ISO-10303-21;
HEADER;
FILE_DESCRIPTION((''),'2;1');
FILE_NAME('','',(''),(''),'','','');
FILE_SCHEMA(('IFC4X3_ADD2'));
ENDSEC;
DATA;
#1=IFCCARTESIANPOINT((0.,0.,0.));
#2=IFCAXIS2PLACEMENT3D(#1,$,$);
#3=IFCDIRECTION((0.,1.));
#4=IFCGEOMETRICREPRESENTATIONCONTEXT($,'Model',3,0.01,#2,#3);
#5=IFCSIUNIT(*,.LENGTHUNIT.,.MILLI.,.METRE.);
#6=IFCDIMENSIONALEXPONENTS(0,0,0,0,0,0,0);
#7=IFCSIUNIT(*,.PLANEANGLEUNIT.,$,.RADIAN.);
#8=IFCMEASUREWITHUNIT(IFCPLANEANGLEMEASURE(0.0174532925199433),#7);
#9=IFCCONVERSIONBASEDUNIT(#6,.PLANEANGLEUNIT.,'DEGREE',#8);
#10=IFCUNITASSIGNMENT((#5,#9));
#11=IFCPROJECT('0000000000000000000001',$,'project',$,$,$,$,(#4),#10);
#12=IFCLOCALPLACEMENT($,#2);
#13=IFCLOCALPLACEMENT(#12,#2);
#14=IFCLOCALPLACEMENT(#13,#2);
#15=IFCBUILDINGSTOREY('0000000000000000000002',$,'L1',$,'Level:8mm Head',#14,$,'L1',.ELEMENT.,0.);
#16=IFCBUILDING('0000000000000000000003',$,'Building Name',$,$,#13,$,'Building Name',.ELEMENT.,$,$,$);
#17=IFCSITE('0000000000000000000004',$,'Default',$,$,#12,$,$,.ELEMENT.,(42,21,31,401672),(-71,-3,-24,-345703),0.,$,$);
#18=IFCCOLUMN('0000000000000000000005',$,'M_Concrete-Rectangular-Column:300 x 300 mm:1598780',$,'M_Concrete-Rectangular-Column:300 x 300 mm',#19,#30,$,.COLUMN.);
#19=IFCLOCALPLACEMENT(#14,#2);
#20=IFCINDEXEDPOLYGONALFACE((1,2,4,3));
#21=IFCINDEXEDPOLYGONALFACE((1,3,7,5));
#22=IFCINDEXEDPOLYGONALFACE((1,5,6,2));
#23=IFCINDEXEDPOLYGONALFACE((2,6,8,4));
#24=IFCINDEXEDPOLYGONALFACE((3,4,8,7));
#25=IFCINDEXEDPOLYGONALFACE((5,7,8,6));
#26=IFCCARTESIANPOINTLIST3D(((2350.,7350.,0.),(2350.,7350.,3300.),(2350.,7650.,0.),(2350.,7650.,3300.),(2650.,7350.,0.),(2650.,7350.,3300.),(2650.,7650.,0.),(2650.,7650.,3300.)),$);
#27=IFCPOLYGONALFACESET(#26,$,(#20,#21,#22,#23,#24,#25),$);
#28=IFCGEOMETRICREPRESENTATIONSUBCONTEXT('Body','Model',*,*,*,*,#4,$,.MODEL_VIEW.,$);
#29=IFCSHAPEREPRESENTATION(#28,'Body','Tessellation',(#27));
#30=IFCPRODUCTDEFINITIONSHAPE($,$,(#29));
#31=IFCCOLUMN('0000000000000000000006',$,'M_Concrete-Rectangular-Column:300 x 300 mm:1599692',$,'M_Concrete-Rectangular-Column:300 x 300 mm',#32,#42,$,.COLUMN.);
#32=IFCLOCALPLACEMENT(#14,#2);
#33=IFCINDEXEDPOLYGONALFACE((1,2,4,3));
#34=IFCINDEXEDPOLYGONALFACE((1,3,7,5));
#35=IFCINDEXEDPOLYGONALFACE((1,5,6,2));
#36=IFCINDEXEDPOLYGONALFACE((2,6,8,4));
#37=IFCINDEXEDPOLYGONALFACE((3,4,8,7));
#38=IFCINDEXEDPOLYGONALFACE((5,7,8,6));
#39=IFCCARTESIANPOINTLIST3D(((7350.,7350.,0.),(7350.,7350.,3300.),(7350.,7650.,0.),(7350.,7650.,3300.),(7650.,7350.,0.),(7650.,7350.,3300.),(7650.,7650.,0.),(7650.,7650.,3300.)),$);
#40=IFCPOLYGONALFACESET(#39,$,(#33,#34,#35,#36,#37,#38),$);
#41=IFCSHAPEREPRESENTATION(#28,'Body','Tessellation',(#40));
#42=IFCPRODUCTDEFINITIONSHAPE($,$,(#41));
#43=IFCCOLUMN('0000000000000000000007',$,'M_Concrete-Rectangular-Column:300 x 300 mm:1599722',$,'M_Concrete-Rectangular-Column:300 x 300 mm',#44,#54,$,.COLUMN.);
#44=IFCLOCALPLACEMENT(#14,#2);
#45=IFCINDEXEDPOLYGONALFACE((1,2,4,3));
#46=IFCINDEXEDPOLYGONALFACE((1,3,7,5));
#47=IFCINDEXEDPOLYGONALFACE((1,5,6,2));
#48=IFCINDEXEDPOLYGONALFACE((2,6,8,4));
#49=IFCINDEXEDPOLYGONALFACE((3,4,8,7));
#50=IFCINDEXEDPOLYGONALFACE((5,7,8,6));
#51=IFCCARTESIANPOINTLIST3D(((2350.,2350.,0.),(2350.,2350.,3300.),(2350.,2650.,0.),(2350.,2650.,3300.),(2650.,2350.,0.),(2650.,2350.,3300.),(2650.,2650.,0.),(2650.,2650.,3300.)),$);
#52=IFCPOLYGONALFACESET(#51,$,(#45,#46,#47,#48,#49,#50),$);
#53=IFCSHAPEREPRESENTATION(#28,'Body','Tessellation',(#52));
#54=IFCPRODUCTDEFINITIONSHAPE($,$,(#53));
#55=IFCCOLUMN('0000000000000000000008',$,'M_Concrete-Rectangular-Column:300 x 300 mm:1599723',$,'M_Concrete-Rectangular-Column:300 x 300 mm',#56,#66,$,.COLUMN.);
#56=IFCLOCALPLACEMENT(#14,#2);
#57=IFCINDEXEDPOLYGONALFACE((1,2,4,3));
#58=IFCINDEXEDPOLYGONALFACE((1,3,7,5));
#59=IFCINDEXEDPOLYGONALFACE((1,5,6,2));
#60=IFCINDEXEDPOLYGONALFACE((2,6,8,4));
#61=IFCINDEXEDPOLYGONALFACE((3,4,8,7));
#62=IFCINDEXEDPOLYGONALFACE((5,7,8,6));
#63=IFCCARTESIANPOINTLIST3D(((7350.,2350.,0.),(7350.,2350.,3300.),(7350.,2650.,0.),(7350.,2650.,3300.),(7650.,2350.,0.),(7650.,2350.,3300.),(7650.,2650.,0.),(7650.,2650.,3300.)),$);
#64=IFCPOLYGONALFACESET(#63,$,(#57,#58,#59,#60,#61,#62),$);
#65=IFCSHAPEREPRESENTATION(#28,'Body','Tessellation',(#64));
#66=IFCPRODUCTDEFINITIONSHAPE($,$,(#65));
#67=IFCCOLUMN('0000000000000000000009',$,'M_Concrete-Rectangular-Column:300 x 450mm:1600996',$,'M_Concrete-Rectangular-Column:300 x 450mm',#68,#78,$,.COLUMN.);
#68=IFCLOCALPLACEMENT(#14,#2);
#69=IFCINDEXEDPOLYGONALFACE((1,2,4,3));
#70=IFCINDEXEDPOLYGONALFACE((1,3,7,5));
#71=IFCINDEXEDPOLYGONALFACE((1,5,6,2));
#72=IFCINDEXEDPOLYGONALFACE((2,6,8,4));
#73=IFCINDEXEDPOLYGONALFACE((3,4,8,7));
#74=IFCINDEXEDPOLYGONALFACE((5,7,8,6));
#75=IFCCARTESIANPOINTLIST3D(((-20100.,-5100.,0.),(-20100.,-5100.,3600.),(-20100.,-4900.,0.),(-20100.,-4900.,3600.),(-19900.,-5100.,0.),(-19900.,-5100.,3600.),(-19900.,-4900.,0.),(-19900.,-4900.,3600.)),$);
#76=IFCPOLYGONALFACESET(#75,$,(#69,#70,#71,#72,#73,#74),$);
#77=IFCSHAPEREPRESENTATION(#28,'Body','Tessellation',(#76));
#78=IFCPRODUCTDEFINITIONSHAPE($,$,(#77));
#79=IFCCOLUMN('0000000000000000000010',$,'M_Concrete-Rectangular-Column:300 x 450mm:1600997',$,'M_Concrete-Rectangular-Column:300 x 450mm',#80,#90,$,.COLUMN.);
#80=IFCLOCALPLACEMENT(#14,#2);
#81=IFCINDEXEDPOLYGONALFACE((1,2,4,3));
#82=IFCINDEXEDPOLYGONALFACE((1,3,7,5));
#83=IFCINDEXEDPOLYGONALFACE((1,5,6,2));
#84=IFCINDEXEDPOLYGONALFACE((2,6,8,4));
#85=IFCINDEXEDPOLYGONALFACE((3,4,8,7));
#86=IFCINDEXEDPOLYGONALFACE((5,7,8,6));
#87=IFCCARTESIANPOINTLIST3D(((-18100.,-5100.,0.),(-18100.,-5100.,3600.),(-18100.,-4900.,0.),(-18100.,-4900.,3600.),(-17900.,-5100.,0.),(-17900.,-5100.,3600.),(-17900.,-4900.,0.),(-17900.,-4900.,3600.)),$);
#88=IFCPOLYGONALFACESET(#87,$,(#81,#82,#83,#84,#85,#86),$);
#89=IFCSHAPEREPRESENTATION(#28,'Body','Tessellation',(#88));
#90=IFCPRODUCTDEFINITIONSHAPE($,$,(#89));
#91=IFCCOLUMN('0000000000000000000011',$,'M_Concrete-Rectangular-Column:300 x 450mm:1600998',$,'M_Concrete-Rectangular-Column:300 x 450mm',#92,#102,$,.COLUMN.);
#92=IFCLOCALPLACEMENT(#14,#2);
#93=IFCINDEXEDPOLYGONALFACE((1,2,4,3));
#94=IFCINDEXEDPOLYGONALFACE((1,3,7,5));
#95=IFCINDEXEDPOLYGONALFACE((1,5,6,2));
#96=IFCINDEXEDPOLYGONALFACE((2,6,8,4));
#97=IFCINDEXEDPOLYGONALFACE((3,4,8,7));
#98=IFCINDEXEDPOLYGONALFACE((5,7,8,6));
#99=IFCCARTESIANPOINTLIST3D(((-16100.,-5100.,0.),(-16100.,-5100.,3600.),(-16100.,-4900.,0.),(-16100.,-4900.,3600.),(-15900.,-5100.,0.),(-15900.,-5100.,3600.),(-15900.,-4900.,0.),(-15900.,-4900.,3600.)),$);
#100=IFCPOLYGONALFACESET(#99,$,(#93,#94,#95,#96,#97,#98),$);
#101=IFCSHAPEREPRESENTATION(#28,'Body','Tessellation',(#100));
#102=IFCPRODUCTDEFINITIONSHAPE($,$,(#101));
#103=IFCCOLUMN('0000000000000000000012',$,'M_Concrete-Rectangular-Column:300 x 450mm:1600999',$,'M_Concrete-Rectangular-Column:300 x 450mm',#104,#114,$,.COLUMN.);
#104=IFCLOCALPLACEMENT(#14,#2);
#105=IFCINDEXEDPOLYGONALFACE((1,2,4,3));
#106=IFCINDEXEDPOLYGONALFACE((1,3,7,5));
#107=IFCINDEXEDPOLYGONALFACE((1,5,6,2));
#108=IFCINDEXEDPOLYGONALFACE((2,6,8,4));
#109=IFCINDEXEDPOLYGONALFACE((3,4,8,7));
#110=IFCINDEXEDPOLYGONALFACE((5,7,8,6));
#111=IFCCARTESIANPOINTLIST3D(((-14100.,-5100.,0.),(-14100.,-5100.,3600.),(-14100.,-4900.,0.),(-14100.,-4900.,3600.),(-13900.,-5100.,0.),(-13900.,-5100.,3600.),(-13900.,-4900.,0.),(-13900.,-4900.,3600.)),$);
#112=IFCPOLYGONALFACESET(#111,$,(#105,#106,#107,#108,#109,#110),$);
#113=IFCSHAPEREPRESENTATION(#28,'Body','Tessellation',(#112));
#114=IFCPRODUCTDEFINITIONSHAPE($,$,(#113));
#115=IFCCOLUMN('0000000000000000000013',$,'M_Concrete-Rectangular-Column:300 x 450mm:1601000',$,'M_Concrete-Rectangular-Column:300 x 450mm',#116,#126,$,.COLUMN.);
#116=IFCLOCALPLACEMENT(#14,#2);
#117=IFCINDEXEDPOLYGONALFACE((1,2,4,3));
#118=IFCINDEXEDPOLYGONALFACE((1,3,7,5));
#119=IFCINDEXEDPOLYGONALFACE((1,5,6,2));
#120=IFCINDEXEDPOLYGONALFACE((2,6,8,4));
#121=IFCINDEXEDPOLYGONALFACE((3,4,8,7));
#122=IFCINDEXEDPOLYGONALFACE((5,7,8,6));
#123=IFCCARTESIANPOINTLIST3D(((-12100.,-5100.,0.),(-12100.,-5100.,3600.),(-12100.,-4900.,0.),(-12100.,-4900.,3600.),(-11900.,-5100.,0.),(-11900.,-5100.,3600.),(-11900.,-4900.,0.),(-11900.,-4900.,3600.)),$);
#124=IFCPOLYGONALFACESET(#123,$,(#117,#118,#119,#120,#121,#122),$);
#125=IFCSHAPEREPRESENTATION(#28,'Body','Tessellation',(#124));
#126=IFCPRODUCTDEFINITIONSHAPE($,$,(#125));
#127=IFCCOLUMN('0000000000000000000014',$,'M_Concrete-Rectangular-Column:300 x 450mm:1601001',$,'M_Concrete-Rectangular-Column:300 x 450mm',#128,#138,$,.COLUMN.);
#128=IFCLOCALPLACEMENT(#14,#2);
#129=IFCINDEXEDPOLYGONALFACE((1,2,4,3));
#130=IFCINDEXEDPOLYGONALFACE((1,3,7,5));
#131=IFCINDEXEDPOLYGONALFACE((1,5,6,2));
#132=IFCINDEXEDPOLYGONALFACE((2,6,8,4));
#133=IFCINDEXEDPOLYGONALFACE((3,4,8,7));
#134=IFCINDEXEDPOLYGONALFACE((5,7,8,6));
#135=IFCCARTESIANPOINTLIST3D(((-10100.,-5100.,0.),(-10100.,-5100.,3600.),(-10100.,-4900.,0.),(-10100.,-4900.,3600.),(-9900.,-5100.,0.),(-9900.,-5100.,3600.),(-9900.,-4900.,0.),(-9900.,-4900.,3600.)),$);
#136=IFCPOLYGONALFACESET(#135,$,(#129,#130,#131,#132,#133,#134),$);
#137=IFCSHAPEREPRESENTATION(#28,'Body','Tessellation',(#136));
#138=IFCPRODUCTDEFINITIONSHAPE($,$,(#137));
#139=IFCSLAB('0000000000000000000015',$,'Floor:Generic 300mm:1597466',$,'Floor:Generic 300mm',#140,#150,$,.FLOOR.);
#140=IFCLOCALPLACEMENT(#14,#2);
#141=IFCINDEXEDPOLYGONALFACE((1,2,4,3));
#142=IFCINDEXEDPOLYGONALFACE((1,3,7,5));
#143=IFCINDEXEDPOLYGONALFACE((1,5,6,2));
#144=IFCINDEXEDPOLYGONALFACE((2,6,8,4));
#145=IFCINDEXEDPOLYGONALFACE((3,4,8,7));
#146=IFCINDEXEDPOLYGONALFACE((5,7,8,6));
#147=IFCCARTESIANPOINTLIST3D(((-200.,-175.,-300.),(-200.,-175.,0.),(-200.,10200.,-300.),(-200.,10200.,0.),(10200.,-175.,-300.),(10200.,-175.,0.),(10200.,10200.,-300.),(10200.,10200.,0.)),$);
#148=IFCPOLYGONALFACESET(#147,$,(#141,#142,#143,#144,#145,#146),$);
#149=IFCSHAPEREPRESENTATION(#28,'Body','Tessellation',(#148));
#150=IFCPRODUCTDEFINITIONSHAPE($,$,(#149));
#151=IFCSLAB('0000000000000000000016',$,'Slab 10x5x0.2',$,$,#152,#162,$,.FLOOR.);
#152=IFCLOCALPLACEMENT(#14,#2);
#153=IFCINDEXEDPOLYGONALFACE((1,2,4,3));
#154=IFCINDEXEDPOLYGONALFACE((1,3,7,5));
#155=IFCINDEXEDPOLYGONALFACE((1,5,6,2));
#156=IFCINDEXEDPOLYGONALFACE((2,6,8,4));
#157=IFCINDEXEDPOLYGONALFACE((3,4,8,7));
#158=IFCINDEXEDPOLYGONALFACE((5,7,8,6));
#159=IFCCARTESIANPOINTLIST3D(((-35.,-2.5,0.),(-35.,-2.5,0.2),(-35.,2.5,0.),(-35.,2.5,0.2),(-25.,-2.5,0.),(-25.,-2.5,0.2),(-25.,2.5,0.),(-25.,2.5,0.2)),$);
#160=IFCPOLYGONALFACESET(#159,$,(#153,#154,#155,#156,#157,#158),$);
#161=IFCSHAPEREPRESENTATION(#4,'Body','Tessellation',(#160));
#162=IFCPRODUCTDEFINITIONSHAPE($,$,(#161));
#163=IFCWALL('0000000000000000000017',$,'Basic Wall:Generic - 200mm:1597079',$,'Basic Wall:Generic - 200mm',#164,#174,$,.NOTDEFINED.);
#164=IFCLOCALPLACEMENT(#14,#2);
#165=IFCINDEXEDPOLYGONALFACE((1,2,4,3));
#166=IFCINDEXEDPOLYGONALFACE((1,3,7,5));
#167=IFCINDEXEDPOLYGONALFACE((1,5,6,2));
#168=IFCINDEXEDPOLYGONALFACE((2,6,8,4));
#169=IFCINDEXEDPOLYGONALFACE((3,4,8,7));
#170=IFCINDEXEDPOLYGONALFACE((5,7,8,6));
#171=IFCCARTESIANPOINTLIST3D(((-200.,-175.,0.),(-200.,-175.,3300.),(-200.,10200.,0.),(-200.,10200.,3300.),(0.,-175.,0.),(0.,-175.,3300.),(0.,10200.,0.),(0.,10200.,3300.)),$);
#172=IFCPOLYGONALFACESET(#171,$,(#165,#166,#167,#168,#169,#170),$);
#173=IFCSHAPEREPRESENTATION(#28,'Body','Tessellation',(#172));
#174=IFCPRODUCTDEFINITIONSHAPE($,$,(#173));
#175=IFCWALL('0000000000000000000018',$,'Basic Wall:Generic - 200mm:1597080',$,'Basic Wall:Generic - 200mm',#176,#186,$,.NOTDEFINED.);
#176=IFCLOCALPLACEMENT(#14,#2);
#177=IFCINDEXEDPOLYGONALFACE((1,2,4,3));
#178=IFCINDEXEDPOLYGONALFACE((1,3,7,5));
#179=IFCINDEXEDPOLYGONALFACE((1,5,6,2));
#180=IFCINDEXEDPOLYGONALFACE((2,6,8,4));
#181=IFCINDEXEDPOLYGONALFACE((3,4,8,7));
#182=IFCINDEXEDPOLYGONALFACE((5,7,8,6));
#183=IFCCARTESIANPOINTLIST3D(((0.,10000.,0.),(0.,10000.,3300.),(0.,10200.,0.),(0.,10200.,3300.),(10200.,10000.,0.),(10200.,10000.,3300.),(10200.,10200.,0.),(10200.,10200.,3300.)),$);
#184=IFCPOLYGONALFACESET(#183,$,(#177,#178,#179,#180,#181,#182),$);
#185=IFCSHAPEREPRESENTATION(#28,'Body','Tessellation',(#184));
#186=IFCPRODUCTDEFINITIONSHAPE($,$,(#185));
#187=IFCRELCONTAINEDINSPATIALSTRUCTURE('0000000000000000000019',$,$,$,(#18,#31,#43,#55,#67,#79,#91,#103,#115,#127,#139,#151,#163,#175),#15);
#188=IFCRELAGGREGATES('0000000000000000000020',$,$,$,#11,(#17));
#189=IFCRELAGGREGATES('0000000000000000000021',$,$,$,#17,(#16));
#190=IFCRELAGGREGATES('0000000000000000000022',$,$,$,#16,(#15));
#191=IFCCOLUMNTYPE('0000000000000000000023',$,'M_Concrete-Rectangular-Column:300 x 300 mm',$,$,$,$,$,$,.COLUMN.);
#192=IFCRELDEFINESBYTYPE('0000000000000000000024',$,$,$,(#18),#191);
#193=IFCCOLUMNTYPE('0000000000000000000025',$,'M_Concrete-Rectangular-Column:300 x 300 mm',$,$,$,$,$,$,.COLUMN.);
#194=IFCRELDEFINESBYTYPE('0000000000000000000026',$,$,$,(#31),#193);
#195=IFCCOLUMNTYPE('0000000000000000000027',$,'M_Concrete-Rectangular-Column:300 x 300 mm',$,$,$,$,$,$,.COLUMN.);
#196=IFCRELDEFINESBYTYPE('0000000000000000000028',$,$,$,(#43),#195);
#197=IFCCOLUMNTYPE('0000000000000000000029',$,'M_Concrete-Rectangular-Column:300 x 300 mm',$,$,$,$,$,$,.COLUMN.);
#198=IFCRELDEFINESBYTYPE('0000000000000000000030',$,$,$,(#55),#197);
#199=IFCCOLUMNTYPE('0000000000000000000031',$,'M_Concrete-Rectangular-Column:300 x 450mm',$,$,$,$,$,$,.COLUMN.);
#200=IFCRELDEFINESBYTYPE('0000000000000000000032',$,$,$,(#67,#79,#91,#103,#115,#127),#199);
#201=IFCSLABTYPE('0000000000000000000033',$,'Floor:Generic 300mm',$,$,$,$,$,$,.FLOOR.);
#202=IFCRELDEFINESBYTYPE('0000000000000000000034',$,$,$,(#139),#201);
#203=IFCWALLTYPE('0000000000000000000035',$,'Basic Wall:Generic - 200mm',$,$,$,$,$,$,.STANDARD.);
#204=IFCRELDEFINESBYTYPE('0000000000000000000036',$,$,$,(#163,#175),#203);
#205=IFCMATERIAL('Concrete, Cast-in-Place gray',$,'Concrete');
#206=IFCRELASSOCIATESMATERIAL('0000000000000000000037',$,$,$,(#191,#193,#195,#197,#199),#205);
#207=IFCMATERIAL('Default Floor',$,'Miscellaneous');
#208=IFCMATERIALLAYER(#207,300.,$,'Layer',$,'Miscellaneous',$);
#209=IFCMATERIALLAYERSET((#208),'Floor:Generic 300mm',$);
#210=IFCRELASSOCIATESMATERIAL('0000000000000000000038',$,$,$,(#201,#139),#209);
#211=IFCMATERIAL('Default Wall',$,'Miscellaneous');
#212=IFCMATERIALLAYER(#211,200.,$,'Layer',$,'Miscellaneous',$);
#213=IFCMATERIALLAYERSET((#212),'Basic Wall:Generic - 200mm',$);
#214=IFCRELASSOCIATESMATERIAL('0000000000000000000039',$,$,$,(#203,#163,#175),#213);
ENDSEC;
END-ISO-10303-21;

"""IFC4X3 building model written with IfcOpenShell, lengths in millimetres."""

from ifc_helpers import new_model, entity, si_unit, converted_unit, direction, frame, frame_2d, origin, origin_with_axes, origin_2d, origin_2d_with_axis, place, context, subcontext, project, spatial, rectangle, extrude, source, transform, mapped, material, layer, layer_set, layer_usage, material_profile, profile_set, type_object, type_shapes, element, save


model = new_model("IFC4X3")

# Units and contexts
model_context = context("Model", 3, precision=0.01, world=origin(), true_north=direction((0.0, 1.0)))
body_context = subcontext(model_context, "Body", "Model", "MODEL_VIEW")
ifc_project = project(units=[si_unit("LENGTHUNIT", "METRE", prefix="MILLI"), converted_unit("PLANEANGLEUNIT", "DEGREE", entity("IfcPlaneAngleMeasure", 0.0174532925199433), si_unit("PLANEANGLEUNIT", "RADIAN"), dimensions=[0, 0, 0, 0, 0, 0, 0])], contexts=[model_context])

# Site, building, storey
site_placement = place(None, origin())
site = spatial("IfcSite", under=ifc_project, at=site_placement, Name="Default", CompositionType="ELEMENT", RefLatitude=(42, 21, 31, 401672), RefLongitude=(-71, -3, -24, -345703), RefElevation=0.0)
building_placement = place(site_placement, origin())
building = spatial("IfcBuilding", under=site, at=building_placement, Name="Building Name", LongName="Building Name", CompositionType="ELEMENT")
storey_placement = place(building_placement, origin())
storey = spatial("IfcBuildingStorey", under=building, at=storey_placement, Name="L1", ObjectType="Level:8mm Head", LongName="L1", CompositionType="ELEMENT", Elevation=0.0)

# Columns
ifc_material_1 = material(Name="Concrete, Cast-in-Place gray", Category="Concrete")
ifc_material_profile_1 = material_profile(ifc_material_1, rectangle(XDim=300.0, YDim=300.0, at=origin_2d_with_axis()), Name="300 x 300 mm")
ifc_profile_set_1 = profile_set([ifc_material_profile_1], Name="300 x 300 mm")
column_type_1 = type_object("IfcColumnType", Name="M_Concrete-Rectangular-Column:300 x 300 mm", PredefinedType="COLUMN", material=ifc_profile_set_1)
shared_shape_1 = source(origin(), body_context, "Body", "SweptSolid", [
    extrude(rectangle(XDim=300.0, YDim=300.0, at=origin_2d_with_axis()), frame((2500.0, 7500.0, 0.0)), (0.0, 0.0, 1.0), 3300.0),
])
type_shapes(column_type_1, [shared_shape_1])
column_1_placement = place(storey_placement, origin())
element("IfcColumn", 1, at=column_1_placement, inside=storey, type_object=column_type_1, Name="M_Concrete-Rectangular-Column:300 x 300 mm:1598780", ObjectType="M_Concrete-Rectangular-Column:300 x 300 mm", PredefinedType="COLUMN", context=body_context, shape_type="MappedRepresentation", body=[
    mapped(shared_shape_1, transform((0.0, 0.0, 0.0), scale=1.0)),
])
column_type_2 = type_object("IfcColumnType", Name="M_Concrete-Rectangular-Column:300 x 300 mm", PredefinedType="COLUMN", material=ifc_profile_set_1)
shared_shape_2 = source(origin(), body_context, "Body", "SweptSolid", [
    extrude(rectangle(XDim=300.0, YDim=300.0, at=origin_2d_with_axis()), frame((7500.0, 7500.0, 0.0)), (0.0, 0.0, 1.0), 3300.0),
])
type_shapes(column_type_2, [shared_shape_2])
column_2_placement = place(storey_placement, origin())
element("IfcColumn", 2, at=column_2_placement, inside=storey, type_object=column_type_2, Name="M_Concrete-Rectangular-Column:300 x 300 mm:1599692", ObjectType="M_Concrete-Rectangular-Column:300 x 300 mm", PredefinedType="COLUMN", context=body_context, shape_type="MappedRepresentation", body=[
    mapped(shared_shape_2, transform((0.0, 0.0, 0.0), scale=1.0)),
])
column_type_3 = type_object("IfcColumnType", Name="M_Concrete-Rectangular-Column:300 x 300 mm", PredefinedType="COLUMN", material=ifc_profile_set_1)
shared_shape_3 = source(origin(), body_context, "Body", "SweptSolid", [
    extrude(rectangle(XDim=300.0, YDim=300.0, at=origin_2d_with_axis()), frame((2500.0, 2500.0, 0.0)), (0.0, 0.0, 1.0), 3300.0),
])
type_shapes(column_type_3, [shared_shape_3])
column_3_placement = place(storey_placement, origin())
element("IfcColumn", 3, at=column_3_placement, inside=storey, type_object=column_type_3, Name="M_Concrete-Rectangular-Column:300 x 300 mm:1599722", ObjectType="M_Concrete-Rectangular-Column:300 x 300 mm", PredefinedType="COLUMN", context=body_context, shape_type="MappedRepresentation", body=[
    mapped(shared_shape_3, transform((0.0, 0.0, 0.0), scale=1.0)),
])
column_type_4 = type_object("IfcColumnType", Name="M_Concrete-Rectangular-Column:300 x 300 mm", PredefinedType="COLUMN", material=ifc_profile_set_1)
shared_shape_4 = source(origin(), body_context, "Body", "SweptSolid", [
    extrude(rectangle(XDim=300.0, YDim=300.0, at=origin_2d_with_axis()), frame((7500.0, 2500.0, 0.0)), (0.0, 0.0, 1.0), 3300.0),
])
type_shapes(column_type_4, [shared_shape_4])
column_4_placement = place(storey_placement, origin())
element("IfcColumn", 4, at=column_4_placement, inside=storey, type_object=column_type_4, Name="M_Concrete-Rectangular-Column:300 x 300 mm:1599723", ObjectType="M_Concrete-Rectangular-Column:300 x 300 mm", PredefinedType="COLUMN", context=body_context, shape_type="MappedRepresentation", body=[
    mapped(shared_shape_4, transform((0.0, 0.0, 0.0), scale=1.0)),
])
ifc_material_profile_2 = material_profile(ifc_material_1, rectangle(XDim=200.0, YDim=200.0, at=origin_2d_with_axis()), Name="300 x 450mm")
ifc_profile_set_2 = profile_set([ifc_material_profile_2], Name="300 x 450mm")
column_type_5 = type_object("IfcColumnType", Name="M_Concrete-Rectangular-Column:300 x 450mm", PredefinedType="COLUMN", material=ifc_profile_set_2)
shared_shape_5 = source(origin(), body_context, "Body", "SweptSolid", [
    extrude(rectangle(XDim=200.0, YDim=200.0, at=origin_2d_with_axis()), frame((0.0, 0.0, 0.0), z_axis=(0.0, 0.0, 1.0), x_axis=(-1.0, 0.0, 0.0)), (0.0, 0.0, 1.0), 3600.0),
])
type_shapes(column_type_5, [shared_shape_5])
for number, where, z_axis, x_axis, name in (
    (5, (-20000.0, -5000.0, 0.0), (0.0, 0.0, 1.0), (0.0, -1.0, 0.0), "M_Concrete-Rectangular-Column:300 x 450mm:1600996"),
    (6, (-18000.0, -5000.0, 0.0), (0.0, 0.0, 1.0), (0.0, -1.0, 0.0), "M_Concrete-Rectangular-Column:300 x 450mm:1600997"),
    (7, (-16000.0, -5000.0, 0.0), (0.0, 0.0, 1.0), (0.0, -1.0, 0.0), "M_Concrete-Rectangular-Column:300 x 450mm:1600998"),
    (8, (-14000.0, -5000.0, 0.0), (0.0, 0.0, 1.0), (0.0, -1.0, 0.0), "M_Concrete-Rectangular-Column:300 x 450mm:1600999"),
    (9, (-12000.0, -5000.0, 0.0), (0.0, 0.0, 1.0), (0.0, -1.0, 0.0), "M_Concrete-Rectangular-Column:300 x 450mm:1601000"),
    (10, (-10000.0, -5000.0, 0.0), (0.0, 0.0, 1.0), (0.0, -1.0, 0.0), "M_Concrete-Rectangular-Column:300 x 450mm:1601001"),
):
    element("IfcColumn", number, at=place(storey_placement, frame(where, z_axis=z_axis, x_axis=x_axis)), inside=storey, type_object=column_type_5, Name=name, ObjectType="M_Concrete-Rectangular-Column:300 x 450mm", PredefinedType="COLUMN", context=body_context, shape_type="MappedRepresentation", body=[
        mapped(shared_shape_5, transform((0.0, 0.0, 0.0), scale=1.0)),
    ])

# Slabs
ifc_material_2 = material(Name="Default Floor", Category="Miscellaneous")
ifc_layer_1 = layer(ifc_material_2, 300.0, Name="Layer", Category="Miscellaneous")
ifc_layer_set_1 = layer_set([ifc_layer_1], Name="Floor:Generic 300mm")
ifc_layer_usage = layer_usage(ifc_layer_set_1, "AXIS3", "POSITIVE", 0.0)
slab_type = type_object("IfcSlabType", Name="Floor:Generic 300mm", PredefinedType="FLOOR", material=ifc_layer_set_1)
slab_1_placement = place(storey_placement, origin())
element("IfcSlab", 11, at=slab_1_placement, inside=storey, type_object=slab_type, material=ifc_layer_usage, Name="Floor:Generic 300mm:1597466", ObjectType="Floor:Generic 300mm", PredefinedType="FLOOR", context=body_context, shape_type="SweptSolid", body=[
    extrude(rectangle(XDim=10375.0, YDim=10400.0, at=origin_2d_with_axis()), frame((5000.0, 5012.5, 0.0), z_axis=(0.0, 0.0, -1.0), x_axis=(0.0, 1.0, 0.0)), (0.0, 0.0, 1.0), 300.0),
])
slab_2_placement = place(storey_placement, frame((-30.0, 0.0, 0.0), z_axis=(0.0, 0.0, 1.0), x_axis=(1.0, 0.0, 0.0)))
element("IfcSlab", 12, at=slab_2_placement, inside=storey, Name="Slab 10x5x0.2", PredefinedType="FLOOR", context=model_context, shape_type="SweptSolid", body=[
    extrude(rectangle(XDim=10.0, YDim=5.0, at=origin_2d()), origin_with_axes(), (0.0, 0.0, 1.0), 0.2),
])

# Walls
ifc_material_3 = material(Name="Default Wall", Category="Miscellaneous")
ifc_layer_2 = layer(ifc_material_3, 200.0, Name="Layer", Category="Miscellaneous")
ifc_layer_set_2 = layer_set([ifc_layer_2], Name="Basic Wall:Generic - 200mm")
wall_type_1 = type_object("IfcWallType", Name="Basic Wall:Generic - 200mm", PredefinedType="STANDARD", material=ifc_layer_set_2)
wall_1_placement = place(storey_placement, frame((-100.0, 10200.0, 0.0), z_axis=(0.0, 0.0, 1.0), x_axis=(0.0, -1.0, 0.0)))
element("IfcWall", 13, at=wall_1_placement, inside=storey, type_object=wall_type_1, material=ifc_layer_set_2, Name="Basic Wall:Generic - 200mm:1597079", ObjectType="Basic Wall:Generic - 200mm", PredefinedType="NOTDEFINED", context=body_context, shape_type="SweptSolid", body=[
    extrude(rectangle(XDim=10375.0, YDim=200.0, at=frame_2d((5187.5, 0.0), x_axis=(-1.0, 0.0))), origin(), (0.0, 0.0, 1.0), 3300.0),
])
wall_2_placement = place(storey_placement, frame((10200.0, 10100.0, 0.0), z_axis=(0.0, 0.0, 1.0), x_axis=(-1.0, 0.0, 0.0)))
element("IfcWall", 14, at=wall_2_placement, inside=storey, type_object=wall_type_1, material=ifc_layer_set_2, Name="Basic Wall:Generic - 200mm:1597080", ObjectType="Basic Wall:Generic - 200mm", PredefinedType="NOTDEFINED", context=body_context, shape_type="SweptSolid", body=[
    extrude(rectangle(XDim=10200.0, YDim=200.0, at=frame_2d((5100.0, 0.0), x_axis=(-1.0, 0.0))), origin(), (0.0, 0.0, 1.0), 3300.0),
])

save(model, "model.ifc")
